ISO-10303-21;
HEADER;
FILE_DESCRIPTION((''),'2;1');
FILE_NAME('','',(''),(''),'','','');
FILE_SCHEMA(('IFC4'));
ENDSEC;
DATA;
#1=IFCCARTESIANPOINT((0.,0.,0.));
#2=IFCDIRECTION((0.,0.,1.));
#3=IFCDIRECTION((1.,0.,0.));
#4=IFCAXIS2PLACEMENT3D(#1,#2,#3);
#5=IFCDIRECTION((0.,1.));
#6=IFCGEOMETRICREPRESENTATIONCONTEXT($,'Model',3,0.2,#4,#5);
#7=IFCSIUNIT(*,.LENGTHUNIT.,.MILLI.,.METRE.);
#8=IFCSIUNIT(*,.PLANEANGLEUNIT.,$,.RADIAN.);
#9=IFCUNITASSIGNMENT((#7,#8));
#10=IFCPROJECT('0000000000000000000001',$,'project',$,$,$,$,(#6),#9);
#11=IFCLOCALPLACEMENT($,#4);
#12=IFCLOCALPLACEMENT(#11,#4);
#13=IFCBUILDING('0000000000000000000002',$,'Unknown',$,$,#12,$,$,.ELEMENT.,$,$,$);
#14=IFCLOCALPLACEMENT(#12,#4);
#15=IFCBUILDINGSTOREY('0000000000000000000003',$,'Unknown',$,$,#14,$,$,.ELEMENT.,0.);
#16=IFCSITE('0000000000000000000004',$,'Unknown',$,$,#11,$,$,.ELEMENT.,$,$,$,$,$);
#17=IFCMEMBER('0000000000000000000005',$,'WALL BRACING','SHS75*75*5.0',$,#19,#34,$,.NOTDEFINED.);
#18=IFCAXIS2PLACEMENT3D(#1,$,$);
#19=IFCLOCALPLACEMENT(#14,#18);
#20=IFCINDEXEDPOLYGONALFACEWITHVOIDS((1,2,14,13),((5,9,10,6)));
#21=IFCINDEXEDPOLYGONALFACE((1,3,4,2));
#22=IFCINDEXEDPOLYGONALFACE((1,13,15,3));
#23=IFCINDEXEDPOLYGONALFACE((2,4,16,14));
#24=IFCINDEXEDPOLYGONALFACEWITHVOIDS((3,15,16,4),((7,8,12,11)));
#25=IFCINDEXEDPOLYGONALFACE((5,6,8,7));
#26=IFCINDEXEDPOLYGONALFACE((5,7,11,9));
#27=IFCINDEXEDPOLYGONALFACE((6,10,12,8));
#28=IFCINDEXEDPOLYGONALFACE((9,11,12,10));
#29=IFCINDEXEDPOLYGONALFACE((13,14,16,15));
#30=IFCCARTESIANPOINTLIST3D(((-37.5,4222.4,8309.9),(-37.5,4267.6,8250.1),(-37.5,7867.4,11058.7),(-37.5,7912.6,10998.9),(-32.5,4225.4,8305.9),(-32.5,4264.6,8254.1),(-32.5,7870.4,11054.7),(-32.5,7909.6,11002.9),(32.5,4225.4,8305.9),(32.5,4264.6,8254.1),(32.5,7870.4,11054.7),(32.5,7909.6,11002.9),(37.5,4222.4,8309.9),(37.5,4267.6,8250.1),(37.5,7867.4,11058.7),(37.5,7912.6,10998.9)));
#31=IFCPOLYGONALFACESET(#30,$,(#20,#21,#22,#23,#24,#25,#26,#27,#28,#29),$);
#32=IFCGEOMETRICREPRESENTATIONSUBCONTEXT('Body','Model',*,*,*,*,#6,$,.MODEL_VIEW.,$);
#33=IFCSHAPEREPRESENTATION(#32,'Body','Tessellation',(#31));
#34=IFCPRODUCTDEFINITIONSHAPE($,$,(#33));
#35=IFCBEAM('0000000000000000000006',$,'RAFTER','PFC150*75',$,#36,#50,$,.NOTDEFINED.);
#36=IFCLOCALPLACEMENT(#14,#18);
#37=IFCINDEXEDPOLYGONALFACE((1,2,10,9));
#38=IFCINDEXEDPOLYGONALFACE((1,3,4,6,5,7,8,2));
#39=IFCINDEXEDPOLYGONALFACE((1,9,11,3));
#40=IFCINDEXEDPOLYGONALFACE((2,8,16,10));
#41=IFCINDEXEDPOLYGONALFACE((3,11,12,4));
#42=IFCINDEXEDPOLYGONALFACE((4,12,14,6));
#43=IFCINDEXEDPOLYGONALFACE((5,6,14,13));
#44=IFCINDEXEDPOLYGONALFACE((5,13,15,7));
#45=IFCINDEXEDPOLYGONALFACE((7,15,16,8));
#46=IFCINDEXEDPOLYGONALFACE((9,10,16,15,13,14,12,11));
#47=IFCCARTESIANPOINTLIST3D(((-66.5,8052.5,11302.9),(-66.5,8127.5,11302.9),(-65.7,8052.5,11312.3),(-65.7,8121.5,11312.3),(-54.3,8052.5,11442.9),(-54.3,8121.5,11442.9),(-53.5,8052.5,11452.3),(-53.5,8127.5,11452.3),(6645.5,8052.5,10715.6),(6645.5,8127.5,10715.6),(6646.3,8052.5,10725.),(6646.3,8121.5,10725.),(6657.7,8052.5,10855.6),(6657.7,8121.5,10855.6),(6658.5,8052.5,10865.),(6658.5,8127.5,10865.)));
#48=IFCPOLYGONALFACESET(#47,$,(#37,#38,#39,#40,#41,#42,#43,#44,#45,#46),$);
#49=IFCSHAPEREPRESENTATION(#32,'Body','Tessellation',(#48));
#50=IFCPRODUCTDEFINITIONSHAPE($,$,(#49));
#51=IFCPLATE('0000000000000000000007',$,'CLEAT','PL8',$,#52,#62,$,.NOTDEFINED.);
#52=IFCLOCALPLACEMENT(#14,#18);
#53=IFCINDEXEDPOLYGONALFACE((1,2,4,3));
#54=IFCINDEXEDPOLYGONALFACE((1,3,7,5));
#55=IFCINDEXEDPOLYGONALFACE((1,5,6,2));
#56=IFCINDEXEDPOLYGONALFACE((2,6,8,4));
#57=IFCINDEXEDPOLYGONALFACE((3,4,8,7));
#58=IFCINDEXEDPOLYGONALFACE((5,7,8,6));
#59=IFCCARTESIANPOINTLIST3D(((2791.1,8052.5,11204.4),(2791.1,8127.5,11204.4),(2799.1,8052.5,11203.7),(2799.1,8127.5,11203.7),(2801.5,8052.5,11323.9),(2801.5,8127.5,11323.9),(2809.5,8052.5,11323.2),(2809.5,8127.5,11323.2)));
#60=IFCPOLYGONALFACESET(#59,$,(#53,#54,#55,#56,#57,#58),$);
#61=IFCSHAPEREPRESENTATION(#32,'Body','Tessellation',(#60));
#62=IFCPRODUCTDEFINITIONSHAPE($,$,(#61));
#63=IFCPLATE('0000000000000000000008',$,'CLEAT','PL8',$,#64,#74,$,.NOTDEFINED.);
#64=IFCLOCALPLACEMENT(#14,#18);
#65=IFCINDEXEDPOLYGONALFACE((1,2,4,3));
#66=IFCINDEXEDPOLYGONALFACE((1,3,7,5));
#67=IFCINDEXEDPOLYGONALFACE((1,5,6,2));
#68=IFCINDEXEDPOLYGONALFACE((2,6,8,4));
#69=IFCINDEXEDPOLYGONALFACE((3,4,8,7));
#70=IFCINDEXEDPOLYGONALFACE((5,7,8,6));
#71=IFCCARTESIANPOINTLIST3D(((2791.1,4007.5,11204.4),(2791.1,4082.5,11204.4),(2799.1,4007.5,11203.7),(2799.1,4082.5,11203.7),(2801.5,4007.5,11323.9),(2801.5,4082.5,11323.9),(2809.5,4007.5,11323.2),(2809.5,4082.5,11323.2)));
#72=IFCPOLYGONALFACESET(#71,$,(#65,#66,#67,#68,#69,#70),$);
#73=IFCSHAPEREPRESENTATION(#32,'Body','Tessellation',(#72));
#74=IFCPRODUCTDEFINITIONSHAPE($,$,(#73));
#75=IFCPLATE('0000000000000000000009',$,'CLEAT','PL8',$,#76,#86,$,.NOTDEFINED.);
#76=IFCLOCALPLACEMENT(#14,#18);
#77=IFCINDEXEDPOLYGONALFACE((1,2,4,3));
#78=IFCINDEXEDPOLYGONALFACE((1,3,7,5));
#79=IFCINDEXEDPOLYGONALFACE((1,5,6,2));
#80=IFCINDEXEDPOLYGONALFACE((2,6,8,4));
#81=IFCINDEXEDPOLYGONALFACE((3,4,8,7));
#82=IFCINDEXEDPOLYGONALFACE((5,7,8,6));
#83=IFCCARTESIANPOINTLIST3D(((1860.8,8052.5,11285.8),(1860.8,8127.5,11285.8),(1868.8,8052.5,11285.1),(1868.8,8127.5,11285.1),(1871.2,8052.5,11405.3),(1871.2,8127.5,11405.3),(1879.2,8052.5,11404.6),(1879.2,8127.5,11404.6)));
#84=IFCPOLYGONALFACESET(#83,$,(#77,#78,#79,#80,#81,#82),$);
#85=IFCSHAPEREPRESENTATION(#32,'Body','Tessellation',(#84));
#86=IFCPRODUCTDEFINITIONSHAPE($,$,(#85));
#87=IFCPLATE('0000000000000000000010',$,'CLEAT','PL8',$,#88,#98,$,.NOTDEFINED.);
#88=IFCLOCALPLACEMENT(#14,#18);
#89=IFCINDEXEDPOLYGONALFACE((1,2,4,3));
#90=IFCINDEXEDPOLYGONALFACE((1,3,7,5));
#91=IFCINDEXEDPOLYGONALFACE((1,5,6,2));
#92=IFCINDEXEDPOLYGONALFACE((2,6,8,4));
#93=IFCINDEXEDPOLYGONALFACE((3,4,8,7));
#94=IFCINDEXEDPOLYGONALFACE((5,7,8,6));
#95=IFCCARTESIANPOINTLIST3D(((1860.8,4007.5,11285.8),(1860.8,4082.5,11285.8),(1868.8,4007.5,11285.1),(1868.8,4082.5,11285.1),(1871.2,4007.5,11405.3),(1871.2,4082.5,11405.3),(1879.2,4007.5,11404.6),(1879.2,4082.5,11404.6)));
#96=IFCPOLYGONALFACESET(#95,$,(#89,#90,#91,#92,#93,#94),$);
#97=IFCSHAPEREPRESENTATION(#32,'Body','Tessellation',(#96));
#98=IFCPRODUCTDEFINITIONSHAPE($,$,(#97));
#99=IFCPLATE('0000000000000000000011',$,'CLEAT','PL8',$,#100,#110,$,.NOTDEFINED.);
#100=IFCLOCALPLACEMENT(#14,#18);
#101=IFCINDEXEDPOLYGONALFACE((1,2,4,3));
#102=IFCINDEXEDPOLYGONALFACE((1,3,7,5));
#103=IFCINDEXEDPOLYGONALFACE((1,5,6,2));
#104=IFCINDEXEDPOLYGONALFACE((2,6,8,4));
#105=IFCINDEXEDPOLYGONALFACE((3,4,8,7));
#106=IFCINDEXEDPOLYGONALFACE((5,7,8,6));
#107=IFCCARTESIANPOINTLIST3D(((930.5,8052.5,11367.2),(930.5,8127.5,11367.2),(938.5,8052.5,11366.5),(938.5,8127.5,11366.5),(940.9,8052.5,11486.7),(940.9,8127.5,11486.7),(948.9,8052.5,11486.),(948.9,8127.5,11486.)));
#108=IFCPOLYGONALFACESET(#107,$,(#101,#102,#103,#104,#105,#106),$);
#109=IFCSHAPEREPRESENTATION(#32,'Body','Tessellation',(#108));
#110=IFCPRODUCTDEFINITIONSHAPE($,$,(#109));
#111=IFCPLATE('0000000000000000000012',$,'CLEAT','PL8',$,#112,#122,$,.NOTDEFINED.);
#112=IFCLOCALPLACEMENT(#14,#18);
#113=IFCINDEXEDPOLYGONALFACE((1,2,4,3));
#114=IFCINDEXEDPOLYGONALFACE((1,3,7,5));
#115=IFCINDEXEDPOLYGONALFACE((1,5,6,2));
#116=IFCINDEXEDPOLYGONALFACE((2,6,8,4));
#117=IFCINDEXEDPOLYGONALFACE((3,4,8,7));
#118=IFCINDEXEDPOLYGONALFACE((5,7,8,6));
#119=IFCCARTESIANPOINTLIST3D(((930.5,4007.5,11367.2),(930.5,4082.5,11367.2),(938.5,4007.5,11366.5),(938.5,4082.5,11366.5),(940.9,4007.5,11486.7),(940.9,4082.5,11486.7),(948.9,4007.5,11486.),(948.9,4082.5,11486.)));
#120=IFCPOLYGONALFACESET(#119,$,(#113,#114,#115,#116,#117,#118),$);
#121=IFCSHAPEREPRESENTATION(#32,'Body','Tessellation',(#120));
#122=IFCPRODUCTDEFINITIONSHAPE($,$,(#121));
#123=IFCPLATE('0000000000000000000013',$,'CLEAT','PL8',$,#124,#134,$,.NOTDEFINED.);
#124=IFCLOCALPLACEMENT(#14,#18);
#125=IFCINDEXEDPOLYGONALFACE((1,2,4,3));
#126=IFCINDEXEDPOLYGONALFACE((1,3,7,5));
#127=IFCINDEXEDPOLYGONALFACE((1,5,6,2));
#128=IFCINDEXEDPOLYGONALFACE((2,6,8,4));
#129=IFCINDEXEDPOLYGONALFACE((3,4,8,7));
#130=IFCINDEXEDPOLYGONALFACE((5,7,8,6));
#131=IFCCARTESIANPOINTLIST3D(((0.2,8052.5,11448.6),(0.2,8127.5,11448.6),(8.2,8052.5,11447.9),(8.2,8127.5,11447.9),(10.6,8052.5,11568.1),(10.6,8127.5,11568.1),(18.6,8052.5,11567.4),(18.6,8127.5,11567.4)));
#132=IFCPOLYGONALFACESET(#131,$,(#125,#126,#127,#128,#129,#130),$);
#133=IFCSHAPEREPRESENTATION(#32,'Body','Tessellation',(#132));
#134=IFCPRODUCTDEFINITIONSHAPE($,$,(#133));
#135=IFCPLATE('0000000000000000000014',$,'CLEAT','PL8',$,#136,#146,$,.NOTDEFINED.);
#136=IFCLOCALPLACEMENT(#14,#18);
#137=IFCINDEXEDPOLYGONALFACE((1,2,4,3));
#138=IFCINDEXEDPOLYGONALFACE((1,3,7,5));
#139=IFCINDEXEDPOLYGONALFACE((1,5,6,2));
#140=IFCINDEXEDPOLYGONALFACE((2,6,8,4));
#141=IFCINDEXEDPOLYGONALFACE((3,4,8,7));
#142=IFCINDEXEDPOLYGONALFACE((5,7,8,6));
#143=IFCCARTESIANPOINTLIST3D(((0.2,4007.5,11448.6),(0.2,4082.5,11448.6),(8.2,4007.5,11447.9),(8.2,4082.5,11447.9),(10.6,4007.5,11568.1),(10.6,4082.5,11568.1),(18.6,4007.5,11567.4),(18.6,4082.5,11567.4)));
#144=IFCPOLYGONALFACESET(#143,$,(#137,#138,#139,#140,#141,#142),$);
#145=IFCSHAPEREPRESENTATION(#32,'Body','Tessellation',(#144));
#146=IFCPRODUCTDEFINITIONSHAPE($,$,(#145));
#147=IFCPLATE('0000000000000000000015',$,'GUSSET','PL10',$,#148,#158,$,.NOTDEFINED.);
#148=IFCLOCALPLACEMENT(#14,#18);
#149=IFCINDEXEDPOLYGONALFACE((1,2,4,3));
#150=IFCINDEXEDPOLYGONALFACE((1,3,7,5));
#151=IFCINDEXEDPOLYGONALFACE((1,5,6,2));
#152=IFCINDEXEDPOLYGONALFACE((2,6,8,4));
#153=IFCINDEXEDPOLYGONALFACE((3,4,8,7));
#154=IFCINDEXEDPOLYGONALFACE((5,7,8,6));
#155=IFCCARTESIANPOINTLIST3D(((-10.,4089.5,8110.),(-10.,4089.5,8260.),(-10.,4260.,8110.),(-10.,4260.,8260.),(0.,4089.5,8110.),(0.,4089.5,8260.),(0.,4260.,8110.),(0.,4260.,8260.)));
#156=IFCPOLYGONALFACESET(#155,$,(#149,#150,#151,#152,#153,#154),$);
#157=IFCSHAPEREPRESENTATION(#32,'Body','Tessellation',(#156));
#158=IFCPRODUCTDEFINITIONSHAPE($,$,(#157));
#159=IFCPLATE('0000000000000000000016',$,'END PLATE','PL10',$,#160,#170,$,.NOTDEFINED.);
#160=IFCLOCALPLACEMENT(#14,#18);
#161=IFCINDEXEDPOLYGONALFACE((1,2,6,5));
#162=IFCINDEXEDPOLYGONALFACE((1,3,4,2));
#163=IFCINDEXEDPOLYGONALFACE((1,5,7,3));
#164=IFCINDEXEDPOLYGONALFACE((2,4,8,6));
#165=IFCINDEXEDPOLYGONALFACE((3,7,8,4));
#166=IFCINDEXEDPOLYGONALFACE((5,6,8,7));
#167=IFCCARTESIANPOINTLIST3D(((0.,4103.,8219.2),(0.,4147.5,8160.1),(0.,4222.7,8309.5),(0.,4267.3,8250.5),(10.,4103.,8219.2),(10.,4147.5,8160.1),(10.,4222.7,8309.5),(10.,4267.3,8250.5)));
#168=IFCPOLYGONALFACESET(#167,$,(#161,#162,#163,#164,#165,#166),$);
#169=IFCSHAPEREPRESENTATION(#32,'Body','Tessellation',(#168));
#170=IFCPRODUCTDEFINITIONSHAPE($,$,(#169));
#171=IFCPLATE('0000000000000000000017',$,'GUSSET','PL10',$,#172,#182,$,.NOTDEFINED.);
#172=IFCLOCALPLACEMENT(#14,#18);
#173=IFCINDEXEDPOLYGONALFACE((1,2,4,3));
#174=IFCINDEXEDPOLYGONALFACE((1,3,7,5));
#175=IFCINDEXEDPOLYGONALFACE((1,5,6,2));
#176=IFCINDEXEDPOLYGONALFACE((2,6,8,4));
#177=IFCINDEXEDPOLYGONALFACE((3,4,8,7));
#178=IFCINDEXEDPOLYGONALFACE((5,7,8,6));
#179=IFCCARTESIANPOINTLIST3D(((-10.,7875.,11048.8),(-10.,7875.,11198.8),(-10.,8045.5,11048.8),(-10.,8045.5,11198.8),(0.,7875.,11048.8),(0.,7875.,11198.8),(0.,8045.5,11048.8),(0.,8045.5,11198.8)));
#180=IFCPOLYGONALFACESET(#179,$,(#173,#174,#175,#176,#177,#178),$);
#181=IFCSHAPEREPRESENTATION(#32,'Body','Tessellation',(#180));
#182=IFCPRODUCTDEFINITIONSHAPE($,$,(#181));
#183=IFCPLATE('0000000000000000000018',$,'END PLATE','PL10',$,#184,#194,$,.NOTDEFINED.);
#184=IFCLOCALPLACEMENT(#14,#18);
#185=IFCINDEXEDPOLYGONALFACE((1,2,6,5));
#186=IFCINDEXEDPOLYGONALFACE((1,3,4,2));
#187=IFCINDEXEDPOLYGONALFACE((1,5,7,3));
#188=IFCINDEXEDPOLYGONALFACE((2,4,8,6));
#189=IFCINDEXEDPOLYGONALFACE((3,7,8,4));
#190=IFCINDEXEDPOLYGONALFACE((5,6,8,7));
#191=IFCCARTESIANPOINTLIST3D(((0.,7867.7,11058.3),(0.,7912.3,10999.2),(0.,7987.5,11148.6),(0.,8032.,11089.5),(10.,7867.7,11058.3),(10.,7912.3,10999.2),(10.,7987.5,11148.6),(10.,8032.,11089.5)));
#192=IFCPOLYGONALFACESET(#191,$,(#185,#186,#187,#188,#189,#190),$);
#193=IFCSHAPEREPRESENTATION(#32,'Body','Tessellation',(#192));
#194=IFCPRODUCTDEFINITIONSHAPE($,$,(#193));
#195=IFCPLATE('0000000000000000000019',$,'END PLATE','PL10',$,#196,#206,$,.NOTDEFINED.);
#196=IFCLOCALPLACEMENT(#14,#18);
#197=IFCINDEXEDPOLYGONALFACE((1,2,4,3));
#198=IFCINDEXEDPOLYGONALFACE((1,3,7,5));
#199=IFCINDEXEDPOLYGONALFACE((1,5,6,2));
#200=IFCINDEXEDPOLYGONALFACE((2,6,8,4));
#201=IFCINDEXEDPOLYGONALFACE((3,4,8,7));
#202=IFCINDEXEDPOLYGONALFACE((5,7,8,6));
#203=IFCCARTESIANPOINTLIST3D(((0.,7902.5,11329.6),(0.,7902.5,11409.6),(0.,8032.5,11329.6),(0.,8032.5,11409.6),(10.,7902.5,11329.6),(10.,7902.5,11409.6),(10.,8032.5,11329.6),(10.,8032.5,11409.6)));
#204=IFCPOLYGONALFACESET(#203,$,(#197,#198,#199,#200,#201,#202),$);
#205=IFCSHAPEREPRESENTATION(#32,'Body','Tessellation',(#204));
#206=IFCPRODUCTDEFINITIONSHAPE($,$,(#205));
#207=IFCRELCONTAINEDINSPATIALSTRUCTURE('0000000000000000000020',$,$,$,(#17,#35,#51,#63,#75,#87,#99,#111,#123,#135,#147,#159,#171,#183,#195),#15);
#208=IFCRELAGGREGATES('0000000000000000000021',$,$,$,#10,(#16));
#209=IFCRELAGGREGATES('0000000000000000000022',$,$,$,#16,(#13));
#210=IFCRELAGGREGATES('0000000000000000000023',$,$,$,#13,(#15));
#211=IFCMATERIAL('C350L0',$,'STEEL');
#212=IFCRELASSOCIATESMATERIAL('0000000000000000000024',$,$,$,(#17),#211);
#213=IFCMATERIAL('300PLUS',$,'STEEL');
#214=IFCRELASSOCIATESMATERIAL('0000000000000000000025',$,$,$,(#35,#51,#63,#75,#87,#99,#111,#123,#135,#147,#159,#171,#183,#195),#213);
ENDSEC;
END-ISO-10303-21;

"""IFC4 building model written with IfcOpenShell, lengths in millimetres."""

from ifc_helpers import new_model, si_unit, direction, frame, origin_with_axes, place, context, subcontext, project, spatial, line, indexed_curve, outline, extrude, material, element, save


model = new_model("IFC4")

# Units and contexts
model_context = context("Model", 3, precision=0.2, world=origin_with_axes(), true_north=direction((0.0, 1.0)))
body_context = subcontext(model_context, "Body", "Model", "MODEL_VIEW")
ifc_project = project(units=[si_unit("LENGTHUNIT", "METRE", prefix="MILLI"), si_unit("PLANEANGLEUNIT", "RADIAN")], contexts=[model_context])

# Site, building, storey
site_placement = place(None, origin_with_axes())
site = spatial("IfcSite", under=ifc_project, at=site_placement, Name="Unknown", CompositionType="ELEMENT")
building_placement = place(site_placement, origin_with_axes())
building = spatial("IfcBuilding", under=site, at=building_placement, Name="Unknown", CompositionType="ELEMENT")
storey_placement = place(building_placement, origin_with_axes())
storey = spatial("IfcBuildingStorey", under=building, at=storey_placement, Name="Unknown", CompositionType="ELEMENT", Elevation=0.0)

# Shared definitions
ifc_material_1 = material(Name="C350L0", Category="STEEL")

# Member
member_placement = place(storey_placement, frame((0.0, 7890.0, 11028.8), z_axis=(0.0, -0.602108, 0.798415), x_axis=(0.0, -0.798415, -0.602108)))
element("IfcMember", 1, at=member_placement, inside=storey, material=ifc_material_1, Name="WALL BRACING", Description="SHS75*75*5.0", PredefinedType="NOTDEFINED", context=body_context, shape_type="SolidModel", body=[
    extrude(outline(indexed_curve([(-37.5, -37.5), (37.5, -37.5), (37.5, 37.5), (-37.5, 37.5)], segments=[line(1, 2, 3, 4, 1)]), holes=[indexed_curve([(-32.5, -32.5), (-32.5, 32.5), (32.5, 32.5), (32.5, -32.5)], segments=[line(1, 2, 3, 4, 1)])]), frame((0.0, 0.0, 0.0), z_axis=(-1.0, 0.0, 0.0), x_axis=(0.0, 0.0, 1.0)), (0.0, 0.0, -1.0), 4565.3),
])

# Beam
ifc_material_2 = material(Name="300PLUS", Category="STEEL")
beam_1_placement = place(storey_placement, frame((-60.0, 8090.0, 11377.6), z_axis=(0.0, -1.0, 0.0), x_axis=(0.996194, 0.0, -0.087167)))
element("IfcBeam", 2, at=beam_1_placement, inside=storey, material=ifc_material_2, Name="RAFTER", Description="PFC150*75", PredefinedType="NOTDEFINED", context=body_context, shape_type="SolidModel", body=[
    extrude(outline(indexed_curve([(-37.5, -75.0), (37.5, -75.0), (37.5, -65.5), (-31.5, -65.5), (-31.5, 65.5), (37.5, 65.5), (37.5, 75.0), (-37.5, 75.0)], segments=[line(1, 2, 3, 4, 5, 6, 7, 8, 1)])), frame((0.0, 0.0, 0.0), z_axis=(-1.0, 0.0, 0.0), x_axis=(0.0, 0.0, 1.0)), (0.0, 0.0, -1.0), 6737.6),
])

# Plates
for number, where, z_axis, x_axis, name in (
    (3, (2795.1, 8127.5, 11204.0), (-0.996234, 0.0, 0.086702), (0.0, -1.0, 0.0), "CLEAT"),
    (4, (2795.1, 4082.5, 11204.0), (-0.996234, 0.0, 0.086702), (0.0, -1.0, 0.0), "CLEAT"),
    (5, (1864.8, 8127.5, 11285.4), (-0.996234, 0.0, 0.086702), (0.0, -1.0, 0.0), "CLEAT"),
    (6, (1864.8, 4082.5, 11285.4), (-0.996234, 0.0, 0.086702), (0.0, -1.0, 0.0), "CLEAT"),
    (7, (934.5, 8127.5, 11366.8), (-0.996234, 0.0, 0.086702), (0.0, -1.0, 0.0), "CLEAT"),
    (8, (934.5, 4082.5, 11366.8), (-0.996234, 0.0, 0.086702), (0.0, -1.0, 0.0), "CLEAT"),
    (9, (4.2, 8127.5, 11448.2), (-0.996234, 0.0, 0.086702), (0.0, -1.0, 0.0), "CLEAT"),
    (10, (4.2, 4082.5, 11448.2), (-0.996234, 0.0, 0.086702), (0.0, -1.0, 0.0), "CLEAT"),
):
    element("IfcPlate", number, at=place(storey_placement, frame(where, z_axis=z_axis, x_axis=x_axis)), inside=storey, material=ifc_material_2, Name=name, Description="PL8", PredefinedType="NOTDEFINED", context=body_context, shape_type="SolidModel", body=[
        extrude(outline(indexed_curve([(0.0, 0.0), (75.0, 0.0), (75.0, 120.0), (0.0, 120.0)], segments=[line(1, 2, 3, 4, 1)])), frame((0.0, 0.0, 4.0), z_axis=(0.0, 0.0, 1.0), x_axis=(1.0, 0.0, 0.0)), (0.0, 0.0, -1.0), 8.0),
    ])
plate_1_placement = place(storey_placement, frame((-5.0, 4089.5, 8260.0), z_axis=(-1.0, 0.0, 0.0), x_axis=(0.0, 1.0, 0.0)))
element("IfcPlate", 11, at=plate_1_placement, inside=storey, material=ifc_material_2, Name="GUSSET", Description="PL10", PredefinedType="NOTDEFINED", context=body_context, shape_type="SolidModel", body=[
    extrude(outline(indexed_curve([(0.0, 0.0), (170.5, 0.0), (170.5, 150.0), (0.0, 150.0)], segments=[line(1, 2, 3, 4, 1)])), frame((0.0, 0.0, 5.0), z_axis=(0.0, 0.0, 1.0), x_axis=(1.0, 0.0, 0.0)), (0.0, 0.0, -1.0), 10.0),
])
plate_2_placement = place(storey_placement, frame((5.0, 4103.0, 8219.2), z_axis=(1.0, 0.0, 0.0), x_axis=(0.0, 0.601513, -0.798863)))
element("IfcPlate", 12, at=plate_2_placement, inside=storey, material=ifc_material_2, Name="END PLATE", Description="PL10", PredefinedType="NOTDEFINED", context=body_context, shape_type="SolidModel", body=[
    extrude(outline(indexed_curve([(0.0, 0.0), (74.0, 0.0), (73.8, 150.1), (-0.1, 149.9)], segments=[line(1, 2, 3, 4, 1)])), frame((0.0, 0.0, 5.0), z_axis=(0.0, 0.0, 1.0), x_axis=(1.0, 0.0, 0.0)), (0.0, 0.0, -1.0), 10.0),
])
plate_3_placement = place(storey_placement, frame((-5.0, 8045.5, 11048.8), z_axis=(-1.0, 0.0, 0.0), x_axis=(0.0, -1.0, 0.0)))
element("IfcPlate", 13, at=plate_3_placement, inside=storey, material=ifc_material_2, Name="GUSSET", Description="PL10", PredefinedType="NOTDEFINED", context=body_context, shape_type="SolidModel", body=[
    extrude(outline(indexed_curve([(0.0, 0.0), (170.5, 0.0), (170.5, 150.0), (0.0, 150.0)], segments=[line(1, 2, 3, 4, 1)])), frame((0.0, 0.0, 5.0), z_axis=(0.0, 0.0, 1.0), x_axis=(1.0, 0.0, 0.0)), (0.0, 0.0, -1.0), 10.0),
])
plate_4_placement = place(storey_placement, frame((5.0, 7867.7, 11058.3), z_axis=(1.0, 0.0, 0.0), x_axis=(0.0, 0.602374, -0.798214)))
element("IfcPlate", 14, at=plate_4_placement, inside=storey, material=ifc_material_2, Name="END PLATE", Description="PL10", PredefinedType="NOTDEFINED", context=body_context, shape_type="SolidModel", body=[
    extrude(outline(indexed_curve([(0.0, 0.0), (74.0, 0.0), (74.1, 149.9), (0.1, 150.0)], segments=[line(1, 2, 3, 4, 1)])), frame((0.0, 0.0, 5.0), z_axis=(0.0, 0.0, 1.0), x_axis=(1.0, 0.0, 0.0)), (0.0, 0.0, -1.0), 10.0),
])
plate_5_placement = place(storey_placement, frame((5.0, 7902.5, 11329.6), z_axis=(1.0, 0.0, 0.0), x_axis=(0.0, 1.0, 0.0)))
element("IfcPlate", 15, at=plate_5_placement, inside=storey, material=ifc_material_2, Name="END PLATE", Description="PL10", PredefinedType="NOTDEFINED", context=body_context, shape_type="SolidModel", body=[
    extrude(outline(indexed_curve([(0.0, 0.0), (130.0, 0.0), (130.0, 80.0), (0.0, 80.0)], segments=[line(1, 2, 3, 4, 1)])), frame((0.0, 0.0, 5.0), z_axis=(0.0, 0.0, 1.0), x_axis=(1.0, 0.0, 0.0)), (0.0, 0.0, -1.0), 10.0),
])

save(model, "model.ifc")
